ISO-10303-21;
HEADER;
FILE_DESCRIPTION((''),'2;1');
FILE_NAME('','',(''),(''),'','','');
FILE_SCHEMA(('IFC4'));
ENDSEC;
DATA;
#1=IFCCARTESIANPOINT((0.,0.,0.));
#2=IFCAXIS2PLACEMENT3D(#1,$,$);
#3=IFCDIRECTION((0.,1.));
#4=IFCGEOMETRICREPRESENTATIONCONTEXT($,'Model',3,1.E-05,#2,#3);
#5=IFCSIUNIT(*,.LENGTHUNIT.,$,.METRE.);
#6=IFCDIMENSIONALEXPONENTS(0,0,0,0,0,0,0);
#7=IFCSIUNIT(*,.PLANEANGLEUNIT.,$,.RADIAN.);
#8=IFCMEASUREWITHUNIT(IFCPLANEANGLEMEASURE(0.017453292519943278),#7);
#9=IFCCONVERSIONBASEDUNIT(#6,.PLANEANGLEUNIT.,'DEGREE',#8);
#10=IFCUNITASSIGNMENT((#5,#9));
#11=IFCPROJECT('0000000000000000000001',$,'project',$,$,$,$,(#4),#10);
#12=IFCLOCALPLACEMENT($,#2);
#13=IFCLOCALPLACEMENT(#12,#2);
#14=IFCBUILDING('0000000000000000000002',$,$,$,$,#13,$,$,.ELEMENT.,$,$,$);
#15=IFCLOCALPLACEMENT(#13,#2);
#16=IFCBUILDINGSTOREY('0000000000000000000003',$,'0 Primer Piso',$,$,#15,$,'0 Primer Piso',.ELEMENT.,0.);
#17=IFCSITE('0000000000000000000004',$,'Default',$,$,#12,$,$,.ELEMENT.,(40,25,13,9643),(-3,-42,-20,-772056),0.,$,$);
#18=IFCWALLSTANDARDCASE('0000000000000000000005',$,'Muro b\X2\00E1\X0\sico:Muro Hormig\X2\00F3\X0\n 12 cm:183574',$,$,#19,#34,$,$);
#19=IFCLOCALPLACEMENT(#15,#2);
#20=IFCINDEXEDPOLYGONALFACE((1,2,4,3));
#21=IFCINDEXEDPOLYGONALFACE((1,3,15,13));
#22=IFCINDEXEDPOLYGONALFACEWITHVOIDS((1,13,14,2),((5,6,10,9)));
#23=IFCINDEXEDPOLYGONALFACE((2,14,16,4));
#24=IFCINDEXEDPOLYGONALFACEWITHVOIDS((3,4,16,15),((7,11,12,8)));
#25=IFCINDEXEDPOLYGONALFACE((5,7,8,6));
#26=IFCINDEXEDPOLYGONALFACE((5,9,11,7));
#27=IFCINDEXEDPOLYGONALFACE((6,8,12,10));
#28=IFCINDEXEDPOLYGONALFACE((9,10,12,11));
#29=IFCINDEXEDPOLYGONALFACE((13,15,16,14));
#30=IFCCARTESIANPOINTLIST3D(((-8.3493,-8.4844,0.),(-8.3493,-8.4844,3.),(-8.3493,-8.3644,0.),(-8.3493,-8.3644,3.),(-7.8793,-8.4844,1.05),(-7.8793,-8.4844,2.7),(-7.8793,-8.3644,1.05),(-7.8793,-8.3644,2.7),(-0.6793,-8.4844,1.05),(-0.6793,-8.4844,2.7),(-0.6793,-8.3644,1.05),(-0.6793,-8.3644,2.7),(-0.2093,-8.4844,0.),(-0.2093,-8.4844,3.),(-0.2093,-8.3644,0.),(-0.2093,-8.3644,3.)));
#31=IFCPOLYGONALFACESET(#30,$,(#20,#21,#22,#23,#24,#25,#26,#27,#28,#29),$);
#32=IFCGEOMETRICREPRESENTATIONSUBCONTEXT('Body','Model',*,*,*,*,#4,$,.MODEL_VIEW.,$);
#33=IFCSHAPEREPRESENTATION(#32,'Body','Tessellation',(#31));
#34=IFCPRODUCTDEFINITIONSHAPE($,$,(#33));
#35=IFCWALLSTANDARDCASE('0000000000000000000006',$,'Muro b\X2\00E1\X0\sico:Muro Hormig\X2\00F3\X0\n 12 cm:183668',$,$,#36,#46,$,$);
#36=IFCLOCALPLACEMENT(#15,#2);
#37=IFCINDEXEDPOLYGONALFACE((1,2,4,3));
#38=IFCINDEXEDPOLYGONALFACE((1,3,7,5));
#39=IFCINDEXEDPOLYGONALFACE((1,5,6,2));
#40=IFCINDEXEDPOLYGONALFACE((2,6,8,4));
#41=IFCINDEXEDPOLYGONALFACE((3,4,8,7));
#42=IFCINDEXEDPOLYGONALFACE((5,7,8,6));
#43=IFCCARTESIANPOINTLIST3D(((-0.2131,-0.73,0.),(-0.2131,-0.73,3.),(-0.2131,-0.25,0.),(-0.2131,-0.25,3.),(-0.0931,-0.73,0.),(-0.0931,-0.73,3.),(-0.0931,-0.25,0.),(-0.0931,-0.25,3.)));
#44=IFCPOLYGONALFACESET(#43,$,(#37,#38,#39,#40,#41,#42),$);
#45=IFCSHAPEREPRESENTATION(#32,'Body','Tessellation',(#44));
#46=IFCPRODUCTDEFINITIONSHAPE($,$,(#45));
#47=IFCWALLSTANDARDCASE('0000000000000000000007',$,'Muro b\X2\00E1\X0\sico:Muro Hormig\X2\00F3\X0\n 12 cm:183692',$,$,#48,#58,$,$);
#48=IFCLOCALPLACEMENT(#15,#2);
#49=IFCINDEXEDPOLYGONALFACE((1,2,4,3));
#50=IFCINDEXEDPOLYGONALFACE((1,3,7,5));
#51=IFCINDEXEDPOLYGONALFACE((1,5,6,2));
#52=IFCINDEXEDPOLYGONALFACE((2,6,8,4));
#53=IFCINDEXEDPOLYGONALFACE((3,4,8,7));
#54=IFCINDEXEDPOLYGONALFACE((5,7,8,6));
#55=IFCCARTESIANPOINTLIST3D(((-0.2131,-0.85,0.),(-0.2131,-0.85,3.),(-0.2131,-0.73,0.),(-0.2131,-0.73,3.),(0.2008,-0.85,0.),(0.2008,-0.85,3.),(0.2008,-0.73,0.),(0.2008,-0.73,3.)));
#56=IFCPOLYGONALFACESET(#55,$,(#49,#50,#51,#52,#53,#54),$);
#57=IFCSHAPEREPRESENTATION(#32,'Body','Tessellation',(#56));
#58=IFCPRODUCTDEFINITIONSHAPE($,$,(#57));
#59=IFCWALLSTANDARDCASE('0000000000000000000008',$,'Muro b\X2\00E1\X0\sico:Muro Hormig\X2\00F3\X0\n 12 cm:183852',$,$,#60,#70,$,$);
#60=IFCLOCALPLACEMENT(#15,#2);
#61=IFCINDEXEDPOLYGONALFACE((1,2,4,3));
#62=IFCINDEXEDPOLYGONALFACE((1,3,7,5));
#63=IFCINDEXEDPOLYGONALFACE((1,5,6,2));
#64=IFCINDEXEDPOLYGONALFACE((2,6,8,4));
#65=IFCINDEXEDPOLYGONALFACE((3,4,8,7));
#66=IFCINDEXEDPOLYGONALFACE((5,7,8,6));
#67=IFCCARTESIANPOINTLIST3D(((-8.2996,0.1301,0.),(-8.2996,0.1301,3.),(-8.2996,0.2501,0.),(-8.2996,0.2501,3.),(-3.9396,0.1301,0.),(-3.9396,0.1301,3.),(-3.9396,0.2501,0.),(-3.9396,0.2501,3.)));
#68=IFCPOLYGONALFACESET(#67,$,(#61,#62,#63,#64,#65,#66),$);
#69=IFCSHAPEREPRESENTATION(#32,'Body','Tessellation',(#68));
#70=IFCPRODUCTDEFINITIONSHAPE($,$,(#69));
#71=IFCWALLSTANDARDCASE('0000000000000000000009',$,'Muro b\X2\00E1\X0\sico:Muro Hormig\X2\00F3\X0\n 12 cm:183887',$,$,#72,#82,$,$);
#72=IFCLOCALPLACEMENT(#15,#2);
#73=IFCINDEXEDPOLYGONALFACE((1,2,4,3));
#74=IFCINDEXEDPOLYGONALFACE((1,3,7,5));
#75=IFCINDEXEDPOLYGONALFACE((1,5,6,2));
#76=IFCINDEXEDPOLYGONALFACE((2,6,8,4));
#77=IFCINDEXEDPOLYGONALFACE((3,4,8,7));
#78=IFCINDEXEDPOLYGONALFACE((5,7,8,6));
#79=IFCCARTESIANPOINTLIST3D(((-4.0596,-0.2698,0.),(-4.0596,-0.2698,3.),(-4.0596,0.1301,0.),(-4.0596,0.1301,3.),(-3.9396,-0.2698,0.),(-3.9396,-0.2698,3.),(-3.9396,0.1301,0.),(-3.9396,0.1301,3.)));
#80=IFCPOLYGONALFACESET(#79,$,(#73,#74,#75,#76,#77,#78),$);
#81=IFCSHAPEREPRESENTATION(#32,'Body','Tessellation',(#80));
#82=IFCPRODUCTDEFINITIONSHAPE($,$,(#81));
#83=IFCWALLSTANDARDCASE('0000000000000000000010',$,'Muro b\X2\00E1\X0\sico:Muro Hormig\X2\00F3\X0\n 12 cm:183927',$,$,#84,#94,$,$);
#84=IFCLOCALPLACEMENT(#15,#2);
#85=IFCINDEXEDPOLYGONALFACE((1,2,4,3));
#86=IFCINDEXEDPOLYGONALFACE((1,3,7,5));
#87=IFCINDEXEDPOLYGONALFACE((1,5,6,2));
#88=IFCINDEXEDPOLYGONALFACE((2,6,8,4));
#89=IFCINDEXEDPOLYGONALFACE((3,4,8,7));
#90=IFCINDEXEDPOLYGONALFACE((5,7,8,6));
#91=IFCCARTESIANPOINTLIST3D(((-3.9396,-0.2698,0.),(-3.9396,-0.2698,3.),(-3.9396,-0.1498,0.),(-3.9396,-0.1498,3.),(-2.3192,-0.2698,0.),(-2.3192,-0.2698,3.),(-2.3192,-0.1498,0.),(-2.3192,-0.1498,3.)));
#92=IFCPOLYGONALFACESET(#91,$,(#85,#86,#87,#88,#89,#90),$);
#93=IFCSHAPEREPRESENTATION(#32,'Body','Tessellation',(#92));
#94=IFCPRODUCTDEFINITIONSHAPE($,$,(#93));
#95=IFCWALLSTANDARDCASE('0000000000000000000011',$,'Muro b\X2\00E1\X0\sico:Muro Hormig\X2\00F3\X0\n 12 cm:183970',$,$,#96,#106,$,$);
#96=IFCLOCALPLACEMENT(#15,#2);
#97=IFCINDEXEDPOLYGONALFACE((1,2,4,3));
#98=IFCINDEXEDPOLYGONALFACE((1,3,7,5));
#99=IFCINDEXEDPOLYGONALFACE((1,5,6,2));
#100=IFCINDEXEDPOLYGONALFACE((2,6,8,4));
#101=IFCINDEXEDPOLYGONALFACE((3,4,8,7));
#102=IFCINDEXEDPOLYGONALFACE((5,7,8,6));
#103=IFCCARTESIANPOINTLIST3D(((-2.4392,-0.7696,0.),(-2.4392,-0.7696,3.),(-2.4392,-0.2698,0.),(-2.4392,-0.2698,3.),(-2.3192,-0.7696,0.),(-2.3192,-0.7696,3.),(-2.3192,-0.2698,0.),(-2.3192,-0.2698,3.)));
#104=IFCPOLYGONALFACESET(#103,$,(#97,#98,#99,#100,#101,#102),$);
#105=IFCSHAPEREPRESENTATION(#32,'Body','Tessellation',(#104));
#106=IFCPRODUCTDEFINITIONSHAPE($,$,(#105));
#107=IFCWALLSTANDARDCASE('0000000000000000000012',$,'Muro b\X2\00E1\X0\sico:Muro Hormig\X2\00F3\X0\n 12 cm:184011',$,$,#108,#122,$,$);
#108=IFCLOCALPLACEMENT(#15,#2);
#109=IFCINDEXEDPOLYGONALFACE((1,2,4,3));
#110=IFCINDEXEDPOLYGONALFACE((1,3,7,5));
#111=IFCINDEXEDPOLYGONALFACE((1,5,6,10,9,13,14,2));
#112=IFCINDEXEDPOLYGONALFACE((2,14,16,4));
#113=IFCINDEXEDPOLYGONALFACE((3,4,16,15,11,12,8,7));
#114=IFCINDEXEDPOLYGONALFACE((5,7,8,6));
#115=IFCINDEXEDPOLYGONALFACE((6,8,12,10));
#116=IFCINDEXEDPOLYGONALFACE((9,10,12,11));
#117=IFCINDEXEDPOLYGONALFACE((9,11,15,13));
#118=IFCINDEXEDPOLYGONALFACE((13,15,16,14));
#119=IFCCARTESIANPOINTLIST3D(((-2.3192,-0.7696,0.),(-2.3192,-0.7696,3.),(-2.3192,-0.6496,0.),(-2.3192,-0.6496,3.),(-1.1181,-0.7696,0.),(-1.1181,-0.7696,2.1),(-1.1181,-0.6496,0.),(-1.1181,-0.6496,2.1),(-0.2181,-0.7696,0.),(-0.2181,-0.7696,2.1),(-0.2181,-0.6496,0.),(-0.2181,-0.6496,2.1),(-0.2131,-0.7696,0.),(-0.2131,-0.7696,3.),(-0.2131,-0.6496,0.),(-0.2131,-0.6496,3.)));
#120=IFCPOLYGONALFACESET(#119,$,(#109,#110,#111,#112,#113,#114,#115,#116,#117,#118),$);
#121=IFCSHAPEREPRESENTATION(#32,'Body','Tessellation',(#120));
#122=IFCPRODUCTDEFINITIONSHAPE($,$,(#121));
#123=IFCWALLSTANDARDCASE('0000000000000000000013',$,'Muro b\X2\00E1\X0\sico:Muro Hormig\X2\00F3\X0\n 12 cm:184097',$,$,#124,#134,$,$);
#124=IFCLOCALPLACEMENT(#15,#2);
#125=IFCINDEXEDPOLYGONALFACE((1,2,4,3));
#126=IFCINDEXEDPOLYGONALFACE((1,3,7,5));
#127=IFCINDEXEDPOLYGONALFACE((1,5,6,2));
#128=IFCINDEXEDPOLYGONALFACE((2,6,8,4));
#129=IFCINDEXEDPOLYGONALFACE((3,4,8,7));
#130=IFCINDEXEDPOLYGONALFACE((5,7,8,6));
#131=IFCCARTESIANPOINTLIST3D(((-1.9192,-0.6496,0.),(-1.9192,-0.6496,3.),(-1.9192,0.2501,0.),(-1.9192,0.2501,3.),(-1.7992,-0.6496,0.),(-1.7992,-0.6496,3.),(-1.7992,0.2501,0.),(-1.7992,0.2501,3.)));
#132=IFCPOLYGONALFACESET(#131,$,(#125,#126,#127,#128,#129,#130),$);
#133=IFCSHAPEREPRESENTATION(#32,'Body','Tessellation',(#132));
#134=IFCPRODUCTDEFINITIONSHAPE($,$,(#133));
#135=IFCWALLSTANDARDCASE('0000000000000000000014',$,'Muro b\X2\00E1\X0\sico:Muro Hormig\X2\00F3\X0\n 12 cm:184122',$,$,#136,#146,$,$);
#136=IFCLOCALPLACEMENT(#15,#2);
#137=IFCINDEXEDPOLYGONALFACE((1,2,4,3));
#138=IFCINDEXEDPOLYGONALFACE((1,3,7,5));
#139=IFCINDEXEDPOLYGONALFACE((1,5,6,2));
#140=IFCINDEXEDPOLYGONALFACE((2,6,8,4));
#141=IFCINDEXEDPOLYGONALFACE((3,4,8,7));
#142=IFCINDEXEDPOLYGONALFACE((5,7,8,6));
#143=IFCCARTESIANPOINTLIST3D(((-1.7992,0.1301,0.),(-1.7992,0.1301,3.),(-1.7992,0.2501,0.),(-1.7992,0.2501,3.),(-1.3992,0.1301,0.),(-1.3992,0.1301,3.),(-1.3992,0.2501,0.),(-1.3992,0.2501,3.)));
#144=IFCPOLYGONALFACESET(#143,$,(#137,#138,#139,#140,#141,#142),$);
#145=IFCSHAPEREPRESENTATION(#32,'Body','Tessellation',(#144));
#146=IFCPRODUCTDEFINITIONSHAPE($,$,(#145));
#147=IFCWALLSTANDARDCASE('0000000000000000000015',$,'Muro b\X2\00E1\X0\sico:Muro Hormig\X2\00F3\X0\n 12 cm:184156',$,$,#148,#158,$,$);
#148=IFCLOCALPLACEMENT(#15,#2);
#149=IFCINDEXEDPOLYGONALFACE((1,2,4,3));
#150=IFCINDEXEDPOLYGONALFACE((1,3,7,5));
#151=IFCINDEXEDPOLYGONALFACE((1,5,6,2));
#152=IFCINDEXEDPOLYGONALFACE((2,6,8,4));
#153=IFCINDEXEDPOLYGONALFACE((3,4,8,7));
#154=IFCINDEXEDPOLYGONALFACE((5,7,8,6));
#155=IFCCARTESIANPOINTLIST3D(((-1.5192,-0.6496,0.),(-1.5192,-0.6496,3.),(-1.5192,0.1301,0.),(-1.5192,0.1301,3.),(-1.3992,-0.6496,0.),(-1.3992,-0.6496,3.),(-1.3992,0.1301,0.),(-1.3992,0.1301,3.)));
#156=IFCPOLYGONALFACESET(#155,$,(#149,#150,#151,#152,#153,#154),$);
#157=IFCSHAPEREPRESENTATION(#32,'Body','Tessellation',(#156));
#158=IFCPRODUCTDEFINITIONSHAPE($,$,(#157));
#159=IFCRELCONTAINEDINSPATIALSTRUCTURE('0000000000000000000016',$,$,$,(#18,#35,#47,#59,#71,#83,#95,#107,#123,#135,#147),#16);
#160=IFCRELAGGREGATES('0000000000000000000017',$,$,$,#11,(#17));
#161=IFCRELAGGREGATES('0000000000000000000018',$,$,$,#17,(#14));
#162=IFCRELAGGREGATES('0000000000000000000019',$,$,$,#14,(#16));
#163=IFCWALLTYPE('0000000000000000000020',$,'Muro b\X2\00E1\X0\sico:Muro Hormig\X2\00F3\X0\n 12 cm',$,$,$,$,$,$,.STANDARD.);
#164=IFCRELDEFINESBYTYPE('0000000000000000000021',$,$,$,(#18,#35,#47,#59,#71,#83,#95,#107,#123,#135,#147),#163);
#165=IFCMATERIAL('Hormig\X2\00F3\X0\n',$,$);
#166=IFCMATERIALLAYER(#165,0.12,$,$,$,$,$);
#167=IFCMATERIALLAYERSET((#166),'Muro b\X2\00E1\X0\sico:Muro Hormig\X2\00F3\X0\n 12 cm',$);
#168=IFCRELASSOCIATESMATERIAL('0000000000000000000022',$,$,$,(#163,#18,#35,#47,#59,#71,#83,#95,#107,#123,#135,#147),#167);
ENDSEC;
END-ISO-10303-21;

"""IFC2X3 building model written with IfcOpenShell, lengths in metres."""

from ifc_helpers import new_model, entity, si_unit, converted_unit, direction, frame, frame_2d, origin, place, context, subcontext, project, spatial, rectangle, extrude, material, layer, layer_set, layer_usage, type_object, element, save


model = new_model("IFC2X3")

# Units and contexts
model_context = context("Model", 3, precision=1e-05, world=origin(), true_north=direction((0.0, 1.0)))
body_context = subcontext(model_context, "Body", "Model", "MODEL_VIEW")
ifc_project = project(units=[si_unit("LENGTHUNIT", "METRE"), converted_unit("PLANEANGLEUNIT", "DEGREE", entity("IfcPlaneAngleMeasure", 0.017453292519943278), si_unit("PLANEANGLEUNIT", "RADIAN"), dimensions=[0, 0, 0, 0, 0, 0, 0])], contexts=[model_context])

# Site, building, storey
site_placement = place(None, origin())
site = spatial("IfcSite", under=ifc_project, at=site_placement, Name="Default", CompositionType="ELEMENT", RefLatitude=(40, 25, 13, 9643), RefLongitude=(-3, -42, -20, -772056), RefElevation=0.0)
building_placement = place(site_placement, origin())
building = spatial("IfcBuilding", under=site, at=building_placement, CompositionType="ELEMENT")
storey_placement = place(building_placement, origin())
storey = spatial("IfcBuildingStorey", under=building, at=storey_placement, Name="0 Primer Piso", LongName="0 Primer Piso", CompositionType="ELEMENT", Elevation=0.0)

# Shared definitions
ifc_material_1 = material(Name="Hormigón")
ifc_layer_1 = layer(ifc_material_1, 0.12)
ifc_layer_set_1 = layer_set([ifc_layer_1], Name="Muro básico:Muro Hormigón 12 cm")
wall_type = type_object("IfcWallType", Name="Muro básico:Muro Hormigón 12 cm", PredefinedType="STANDARD", material=ifc_layer_set_1)

# Wall, opening
ifc_layer_usage_1 = layer_usage(ifc_layer_set_1, "AXIS2", "NEGATIVE", 0.06)
wall_1_placement = place(storey_placement, frame((-8.3493, -8.4244, 0.0)))
wall_1 = element("IfcWallStandardCase", 1, at=wall_1_placement, inside=storey, type_object=wall_type, material=ifc_layer_usage_1, Name="Muro básico:Muro Hormigón 12 cm:183574", context=body_context, shape_type="SweptSolid", body=[
    extrude(rectangle(XDim=8.14, YDim=0.12, at=frame_2d((4.07, 0.0), x_axis=(-1.0, 0.0))), origin(), (0.0, 0.0, 1.0), 3.0),
])
opening_1_placement = place(wall_1_placement, frame((0.47, -0.06, 1.05)))
element("IfcOpeningElement", 2, at=opening_1_placement, cuts=wall_1, ObjectType="Opening", context=body_context, shape_type="SweptSolid", body=[
    extrude(rectangle(XDim=1.65, YDim=7.2, at=frame_2d((0.825, 3.6), x_axis=(1.0, 0.0))), frame((0.0, 0.0, 0.0), z_axis=(0.0, 1.0, 0.0), x_axis=(0.0, 0.0, 1.0)), (0.0, 0.0, 1.0), 0.12),
])

# Walls
ifc_layer_usage_2 = layer_usage(ifc_layer_set_1, "AXIS2", "NEGATIVE", 0.06)
wall_2_placement = place(storey_placement, frame((-0.1531, -0.25, 0.0), z_axis=(0.0, 0.0, 1.0), x_axis=(0.0, -1.0, 0.0)))
element("IfcWallStandardCase", 3, at=wall_2_placement, inside=storey, type_object=wall_type, material=ifc_layer_usage_2, Name="Muro básico:Muro Hormigón 12 cm:183668", context=body_context, shape_type="SweptSolid", body=[
    extrude(rectangle(XDim=0.48, YDim=0.12, at=frame_2d((0.24, 0.0), x_axis=(-1.0, 0.0))), origin(), (0.0, 0.0, 1.0), 3.0),
])
ifc_layer_usage_3 = layer_usage(ifc_layer_set_1, "AXIS2", "NEGATIVE", 0.06)
wall_3_placement = place(storey_placement, frame((-0.2131, -0.79, 0.0)))
element("IfcWallStandardCase", 4, at=wall_3_placement, inside=storey, type_object=wall_type, material=ifc_layer_usage_3, Name="Muro básico:Muro Hormigón 12 cm:183692", context=body_context, shape_type="SweptSolid", body=[
    extrude(rectangle(XDim=0.4139, YDim=0.12, at=frame_2d((0.207, 0.0), x_axis=(-1.0, 0.0))), origin(), (0.0, 0.0, 1.0), 3.0),
])
ifc_layer_usage_4 = layer_usage(ifc_layer_set_1, "AXIS2", "NEGATIVE", 0.06)
wall_4_placement = place(storey_placement, frame((-8.2996, 0.1901, 0.0)))
element("IfcWallStandardCase", 5, at=wall_4_placement, inside=storey, type_object=wall_type, material=ifc_layer_usage_4, Name="Muro básico:Muro Hormigón 12 cm:183852", context=body_context, shape_type="SweptSolid", body=[
    extrude(rectangle(XDim=4.36, YDim=0.12, at=frame_2d((2.18, 0.0), x_axis=(-1.0, 0.0))), origin(), (0.0, 0.0, 1.0), 3.0),
])
ifc_layer_usage_5 = layer_usage(ifc_layer_set_1, "AXIS2", "NEGATIVE", 0.06)
wall_5_placement = place(storey_placement, frame((-3.9996, 0.1301, 0.0), z_axis=(0.0, 0.0, 1.0), x_axis=(0.0, -1.0, 0.0)))
element("IfcWallStandardCase", 6, at=wall_5_placement, inside=storey, type_object=wall_type, material=ifc_layer_usage_5, Name="Muro básico:Muro Hormigón 12 cm:183887", context=body_context, shape_type="SweptSolid", body=[
    extrude(rectangle(XDim=0.3998, YDim=0.12, at=frame_2d((0.1999, 0.0), x_axis=(-1.0, 0.0))), origin(), (0.0, 0.0, 1.0), 3.0),
])
ifc_layer_usage_6 = layer_usage(ifc_layer_set_1, "AXIS2", "NEGATIVE", 0.06)
wall_6_placement = place(storey_placement, frame((-3.9396, -0.2098, 0.0)))
element("IfcWallStandardCase", 7, at=wall_6_placement, inside=storey, type_object=wall_type, material=ifc_layer_usage_6, Name="Muro básico:Muro Hormigón 12 cm:183927", context=body_context, shape_type="SweptSolid", body=[
    extrude(rectangle(XDim=1.6204, YDim=0.12, at=frame_2d((0.8102, 0.0), x_axis=(-1.0, 0.0))), origin(), (0.0, 0.0, 1.0), 3.0),
])
ifc_layer_usage_7 = layer_usage(ifc_layer_set_1, "AXIS2", "NEGATIVE", 0.06)
wall_7_placement = place(storey_placement, frame((-2.3792, -0.2698, 0.0), z_axis=(0.0, 0.0, 1.0), x_axis=(0.0, -1.0, 0.0)))
element("IfcWallStandardCase", 8, at=wall_7_placement, inside=storey, type_object=wall_type, material=ifc_layer_usage_7, Name="Muro básico:Muro Hormigón 12 cm:183970", context=body_context, shape_type="SweptSolid", body=[
    extrude(rectangle(XDim=0.4998, YDim=0.12, at=frame_2d((0.2499, 0.0), x_axis=(-1.0, 0.0))), origin(), (0.0, 0.0, 1.0), 3.0),
])

# Wall, opening
ifc_layer_usage_8 = layer_usage(ifc_layer_set_1, "AXIS2", "NEGATIVE", 0.06)
wall_8_placement = place(storey_placement, frame((-2.3192, -0.7096, 0.0)))
wall_8 = element("IfcWallStandardCase", 9, at=wall_8_placement, inside=storey, type_object=wall_type, material=ifc_layer_usage_8, Name="Muro básico:Muro Hormigón 12 cm:184011", context=body_context, shape_type="SweptSolid", body=[
    extrude(rectangle(XDim=2.106, YDim=0.12, at=frame_2d((1.053, 0.0), x_axis=(-1.0, 0.0))), origin(), (0.0, 0.0, 1.0), 3.0),
])
opening_2_placement = place(wall_8_placement, frame((1.201, -0.06, 0.0)))
element("IfcOpeningElement", 10, at=opening_2_placement, cuts=wall_8, ObjectType="Opening", context=body_context, shape_type="SweptSolid", body=[
    extrude(rectangle(XDim=2.1, YDim=0.9, at=frame_2d((1.05, 0.45), x_axis=(1.0, 0.0))), frame((0.0, 0.0, 0.0), z_axis=(0.0, 1.0, 0.0), x_axis=(0.0, 0.0, 1.0)), (0.0, 0.0, 1.0), 0.12),
])

# Walls
ifc_layer_usage_9 = layer_usage(ifc_layer_set_1, "AXIS2", "NEGATIVE", 0.06)
wall_9_placement = place(storey_placement, frame((-1.8592, -0.6496, 0.0), z_axis=(0.0, 0.0, 1.0), x_axis=(0.0, 1.0, 0.0)))
element("IfcWallStandardCase", 11, at=wall_9_placement, inside=storey, type_object=wall_type, material=ifc_layer_usage_9, Name="Muro básico:Muro Hormigón 12 cm:184097", context=body_context, shape_type="SweptSolid", body=[
    extrude(rectangle(XDim=0.8996, YDim=0.12, at=frame_2d((0.4498, 0.0), x_axis=(-1.0, 0.0))), origin(), (0.0, 0.0, 1.0), 3.0),
])
ifc_layer_usage_10 = layer_usage(ifc_layer_set_1, "AXIS2", "NEGATIVE", 0.06)
wall_10_placement = place(storey_placement, frame((-1.7992, 0.1901, 0.0)))
element("IfcWallStandardCase", 12, at=wall_10_placement, inside=storey, type_object=wall_type, material=ifc_layer_usage_10, Name="Muro básico:Muro Hormigón 12 cm:184122", context=body_context, shape_type="SweptSolid", body=[
    extrude(rectangle(XDim=0.4, YDim=0.12, at=frame_2d((0.2, 0.0), x_axis=(-1.0, 0.0))), origin(), (0.0, 0.0, 1.0), 3.0),
])
ifc_layer_usage_11 = layer_usage(ifc_layer_set_1, "AXIS2", "NEGATIVE", 0.06)
wall_11_placement = place(storey_placement, frame((-1.4592, 0.1301, 0.0), z_axis=(0.0, 0.0, 1.0), x_axis=(0.0, -1.0, 0.0)))
element("IfcWallStandardCase", 13, at=wall_11_placement, inside=storey, type_object=wall_type, material=ifc_layer_usage_11, Name="Muro básico:Muro Hormigón 12 cm:184156", context=body_context, shape_type="SweptSolid", body=[
    extrude(rectangle(XDim=0.7796, YDim=0.12, at=frame_2d((0.3898, 0.0), x_axis=(-1.0, 0.0))), origin(), (0.0, 0.0, 1.0), 3.0),
])

save(model, "model.ifc")
